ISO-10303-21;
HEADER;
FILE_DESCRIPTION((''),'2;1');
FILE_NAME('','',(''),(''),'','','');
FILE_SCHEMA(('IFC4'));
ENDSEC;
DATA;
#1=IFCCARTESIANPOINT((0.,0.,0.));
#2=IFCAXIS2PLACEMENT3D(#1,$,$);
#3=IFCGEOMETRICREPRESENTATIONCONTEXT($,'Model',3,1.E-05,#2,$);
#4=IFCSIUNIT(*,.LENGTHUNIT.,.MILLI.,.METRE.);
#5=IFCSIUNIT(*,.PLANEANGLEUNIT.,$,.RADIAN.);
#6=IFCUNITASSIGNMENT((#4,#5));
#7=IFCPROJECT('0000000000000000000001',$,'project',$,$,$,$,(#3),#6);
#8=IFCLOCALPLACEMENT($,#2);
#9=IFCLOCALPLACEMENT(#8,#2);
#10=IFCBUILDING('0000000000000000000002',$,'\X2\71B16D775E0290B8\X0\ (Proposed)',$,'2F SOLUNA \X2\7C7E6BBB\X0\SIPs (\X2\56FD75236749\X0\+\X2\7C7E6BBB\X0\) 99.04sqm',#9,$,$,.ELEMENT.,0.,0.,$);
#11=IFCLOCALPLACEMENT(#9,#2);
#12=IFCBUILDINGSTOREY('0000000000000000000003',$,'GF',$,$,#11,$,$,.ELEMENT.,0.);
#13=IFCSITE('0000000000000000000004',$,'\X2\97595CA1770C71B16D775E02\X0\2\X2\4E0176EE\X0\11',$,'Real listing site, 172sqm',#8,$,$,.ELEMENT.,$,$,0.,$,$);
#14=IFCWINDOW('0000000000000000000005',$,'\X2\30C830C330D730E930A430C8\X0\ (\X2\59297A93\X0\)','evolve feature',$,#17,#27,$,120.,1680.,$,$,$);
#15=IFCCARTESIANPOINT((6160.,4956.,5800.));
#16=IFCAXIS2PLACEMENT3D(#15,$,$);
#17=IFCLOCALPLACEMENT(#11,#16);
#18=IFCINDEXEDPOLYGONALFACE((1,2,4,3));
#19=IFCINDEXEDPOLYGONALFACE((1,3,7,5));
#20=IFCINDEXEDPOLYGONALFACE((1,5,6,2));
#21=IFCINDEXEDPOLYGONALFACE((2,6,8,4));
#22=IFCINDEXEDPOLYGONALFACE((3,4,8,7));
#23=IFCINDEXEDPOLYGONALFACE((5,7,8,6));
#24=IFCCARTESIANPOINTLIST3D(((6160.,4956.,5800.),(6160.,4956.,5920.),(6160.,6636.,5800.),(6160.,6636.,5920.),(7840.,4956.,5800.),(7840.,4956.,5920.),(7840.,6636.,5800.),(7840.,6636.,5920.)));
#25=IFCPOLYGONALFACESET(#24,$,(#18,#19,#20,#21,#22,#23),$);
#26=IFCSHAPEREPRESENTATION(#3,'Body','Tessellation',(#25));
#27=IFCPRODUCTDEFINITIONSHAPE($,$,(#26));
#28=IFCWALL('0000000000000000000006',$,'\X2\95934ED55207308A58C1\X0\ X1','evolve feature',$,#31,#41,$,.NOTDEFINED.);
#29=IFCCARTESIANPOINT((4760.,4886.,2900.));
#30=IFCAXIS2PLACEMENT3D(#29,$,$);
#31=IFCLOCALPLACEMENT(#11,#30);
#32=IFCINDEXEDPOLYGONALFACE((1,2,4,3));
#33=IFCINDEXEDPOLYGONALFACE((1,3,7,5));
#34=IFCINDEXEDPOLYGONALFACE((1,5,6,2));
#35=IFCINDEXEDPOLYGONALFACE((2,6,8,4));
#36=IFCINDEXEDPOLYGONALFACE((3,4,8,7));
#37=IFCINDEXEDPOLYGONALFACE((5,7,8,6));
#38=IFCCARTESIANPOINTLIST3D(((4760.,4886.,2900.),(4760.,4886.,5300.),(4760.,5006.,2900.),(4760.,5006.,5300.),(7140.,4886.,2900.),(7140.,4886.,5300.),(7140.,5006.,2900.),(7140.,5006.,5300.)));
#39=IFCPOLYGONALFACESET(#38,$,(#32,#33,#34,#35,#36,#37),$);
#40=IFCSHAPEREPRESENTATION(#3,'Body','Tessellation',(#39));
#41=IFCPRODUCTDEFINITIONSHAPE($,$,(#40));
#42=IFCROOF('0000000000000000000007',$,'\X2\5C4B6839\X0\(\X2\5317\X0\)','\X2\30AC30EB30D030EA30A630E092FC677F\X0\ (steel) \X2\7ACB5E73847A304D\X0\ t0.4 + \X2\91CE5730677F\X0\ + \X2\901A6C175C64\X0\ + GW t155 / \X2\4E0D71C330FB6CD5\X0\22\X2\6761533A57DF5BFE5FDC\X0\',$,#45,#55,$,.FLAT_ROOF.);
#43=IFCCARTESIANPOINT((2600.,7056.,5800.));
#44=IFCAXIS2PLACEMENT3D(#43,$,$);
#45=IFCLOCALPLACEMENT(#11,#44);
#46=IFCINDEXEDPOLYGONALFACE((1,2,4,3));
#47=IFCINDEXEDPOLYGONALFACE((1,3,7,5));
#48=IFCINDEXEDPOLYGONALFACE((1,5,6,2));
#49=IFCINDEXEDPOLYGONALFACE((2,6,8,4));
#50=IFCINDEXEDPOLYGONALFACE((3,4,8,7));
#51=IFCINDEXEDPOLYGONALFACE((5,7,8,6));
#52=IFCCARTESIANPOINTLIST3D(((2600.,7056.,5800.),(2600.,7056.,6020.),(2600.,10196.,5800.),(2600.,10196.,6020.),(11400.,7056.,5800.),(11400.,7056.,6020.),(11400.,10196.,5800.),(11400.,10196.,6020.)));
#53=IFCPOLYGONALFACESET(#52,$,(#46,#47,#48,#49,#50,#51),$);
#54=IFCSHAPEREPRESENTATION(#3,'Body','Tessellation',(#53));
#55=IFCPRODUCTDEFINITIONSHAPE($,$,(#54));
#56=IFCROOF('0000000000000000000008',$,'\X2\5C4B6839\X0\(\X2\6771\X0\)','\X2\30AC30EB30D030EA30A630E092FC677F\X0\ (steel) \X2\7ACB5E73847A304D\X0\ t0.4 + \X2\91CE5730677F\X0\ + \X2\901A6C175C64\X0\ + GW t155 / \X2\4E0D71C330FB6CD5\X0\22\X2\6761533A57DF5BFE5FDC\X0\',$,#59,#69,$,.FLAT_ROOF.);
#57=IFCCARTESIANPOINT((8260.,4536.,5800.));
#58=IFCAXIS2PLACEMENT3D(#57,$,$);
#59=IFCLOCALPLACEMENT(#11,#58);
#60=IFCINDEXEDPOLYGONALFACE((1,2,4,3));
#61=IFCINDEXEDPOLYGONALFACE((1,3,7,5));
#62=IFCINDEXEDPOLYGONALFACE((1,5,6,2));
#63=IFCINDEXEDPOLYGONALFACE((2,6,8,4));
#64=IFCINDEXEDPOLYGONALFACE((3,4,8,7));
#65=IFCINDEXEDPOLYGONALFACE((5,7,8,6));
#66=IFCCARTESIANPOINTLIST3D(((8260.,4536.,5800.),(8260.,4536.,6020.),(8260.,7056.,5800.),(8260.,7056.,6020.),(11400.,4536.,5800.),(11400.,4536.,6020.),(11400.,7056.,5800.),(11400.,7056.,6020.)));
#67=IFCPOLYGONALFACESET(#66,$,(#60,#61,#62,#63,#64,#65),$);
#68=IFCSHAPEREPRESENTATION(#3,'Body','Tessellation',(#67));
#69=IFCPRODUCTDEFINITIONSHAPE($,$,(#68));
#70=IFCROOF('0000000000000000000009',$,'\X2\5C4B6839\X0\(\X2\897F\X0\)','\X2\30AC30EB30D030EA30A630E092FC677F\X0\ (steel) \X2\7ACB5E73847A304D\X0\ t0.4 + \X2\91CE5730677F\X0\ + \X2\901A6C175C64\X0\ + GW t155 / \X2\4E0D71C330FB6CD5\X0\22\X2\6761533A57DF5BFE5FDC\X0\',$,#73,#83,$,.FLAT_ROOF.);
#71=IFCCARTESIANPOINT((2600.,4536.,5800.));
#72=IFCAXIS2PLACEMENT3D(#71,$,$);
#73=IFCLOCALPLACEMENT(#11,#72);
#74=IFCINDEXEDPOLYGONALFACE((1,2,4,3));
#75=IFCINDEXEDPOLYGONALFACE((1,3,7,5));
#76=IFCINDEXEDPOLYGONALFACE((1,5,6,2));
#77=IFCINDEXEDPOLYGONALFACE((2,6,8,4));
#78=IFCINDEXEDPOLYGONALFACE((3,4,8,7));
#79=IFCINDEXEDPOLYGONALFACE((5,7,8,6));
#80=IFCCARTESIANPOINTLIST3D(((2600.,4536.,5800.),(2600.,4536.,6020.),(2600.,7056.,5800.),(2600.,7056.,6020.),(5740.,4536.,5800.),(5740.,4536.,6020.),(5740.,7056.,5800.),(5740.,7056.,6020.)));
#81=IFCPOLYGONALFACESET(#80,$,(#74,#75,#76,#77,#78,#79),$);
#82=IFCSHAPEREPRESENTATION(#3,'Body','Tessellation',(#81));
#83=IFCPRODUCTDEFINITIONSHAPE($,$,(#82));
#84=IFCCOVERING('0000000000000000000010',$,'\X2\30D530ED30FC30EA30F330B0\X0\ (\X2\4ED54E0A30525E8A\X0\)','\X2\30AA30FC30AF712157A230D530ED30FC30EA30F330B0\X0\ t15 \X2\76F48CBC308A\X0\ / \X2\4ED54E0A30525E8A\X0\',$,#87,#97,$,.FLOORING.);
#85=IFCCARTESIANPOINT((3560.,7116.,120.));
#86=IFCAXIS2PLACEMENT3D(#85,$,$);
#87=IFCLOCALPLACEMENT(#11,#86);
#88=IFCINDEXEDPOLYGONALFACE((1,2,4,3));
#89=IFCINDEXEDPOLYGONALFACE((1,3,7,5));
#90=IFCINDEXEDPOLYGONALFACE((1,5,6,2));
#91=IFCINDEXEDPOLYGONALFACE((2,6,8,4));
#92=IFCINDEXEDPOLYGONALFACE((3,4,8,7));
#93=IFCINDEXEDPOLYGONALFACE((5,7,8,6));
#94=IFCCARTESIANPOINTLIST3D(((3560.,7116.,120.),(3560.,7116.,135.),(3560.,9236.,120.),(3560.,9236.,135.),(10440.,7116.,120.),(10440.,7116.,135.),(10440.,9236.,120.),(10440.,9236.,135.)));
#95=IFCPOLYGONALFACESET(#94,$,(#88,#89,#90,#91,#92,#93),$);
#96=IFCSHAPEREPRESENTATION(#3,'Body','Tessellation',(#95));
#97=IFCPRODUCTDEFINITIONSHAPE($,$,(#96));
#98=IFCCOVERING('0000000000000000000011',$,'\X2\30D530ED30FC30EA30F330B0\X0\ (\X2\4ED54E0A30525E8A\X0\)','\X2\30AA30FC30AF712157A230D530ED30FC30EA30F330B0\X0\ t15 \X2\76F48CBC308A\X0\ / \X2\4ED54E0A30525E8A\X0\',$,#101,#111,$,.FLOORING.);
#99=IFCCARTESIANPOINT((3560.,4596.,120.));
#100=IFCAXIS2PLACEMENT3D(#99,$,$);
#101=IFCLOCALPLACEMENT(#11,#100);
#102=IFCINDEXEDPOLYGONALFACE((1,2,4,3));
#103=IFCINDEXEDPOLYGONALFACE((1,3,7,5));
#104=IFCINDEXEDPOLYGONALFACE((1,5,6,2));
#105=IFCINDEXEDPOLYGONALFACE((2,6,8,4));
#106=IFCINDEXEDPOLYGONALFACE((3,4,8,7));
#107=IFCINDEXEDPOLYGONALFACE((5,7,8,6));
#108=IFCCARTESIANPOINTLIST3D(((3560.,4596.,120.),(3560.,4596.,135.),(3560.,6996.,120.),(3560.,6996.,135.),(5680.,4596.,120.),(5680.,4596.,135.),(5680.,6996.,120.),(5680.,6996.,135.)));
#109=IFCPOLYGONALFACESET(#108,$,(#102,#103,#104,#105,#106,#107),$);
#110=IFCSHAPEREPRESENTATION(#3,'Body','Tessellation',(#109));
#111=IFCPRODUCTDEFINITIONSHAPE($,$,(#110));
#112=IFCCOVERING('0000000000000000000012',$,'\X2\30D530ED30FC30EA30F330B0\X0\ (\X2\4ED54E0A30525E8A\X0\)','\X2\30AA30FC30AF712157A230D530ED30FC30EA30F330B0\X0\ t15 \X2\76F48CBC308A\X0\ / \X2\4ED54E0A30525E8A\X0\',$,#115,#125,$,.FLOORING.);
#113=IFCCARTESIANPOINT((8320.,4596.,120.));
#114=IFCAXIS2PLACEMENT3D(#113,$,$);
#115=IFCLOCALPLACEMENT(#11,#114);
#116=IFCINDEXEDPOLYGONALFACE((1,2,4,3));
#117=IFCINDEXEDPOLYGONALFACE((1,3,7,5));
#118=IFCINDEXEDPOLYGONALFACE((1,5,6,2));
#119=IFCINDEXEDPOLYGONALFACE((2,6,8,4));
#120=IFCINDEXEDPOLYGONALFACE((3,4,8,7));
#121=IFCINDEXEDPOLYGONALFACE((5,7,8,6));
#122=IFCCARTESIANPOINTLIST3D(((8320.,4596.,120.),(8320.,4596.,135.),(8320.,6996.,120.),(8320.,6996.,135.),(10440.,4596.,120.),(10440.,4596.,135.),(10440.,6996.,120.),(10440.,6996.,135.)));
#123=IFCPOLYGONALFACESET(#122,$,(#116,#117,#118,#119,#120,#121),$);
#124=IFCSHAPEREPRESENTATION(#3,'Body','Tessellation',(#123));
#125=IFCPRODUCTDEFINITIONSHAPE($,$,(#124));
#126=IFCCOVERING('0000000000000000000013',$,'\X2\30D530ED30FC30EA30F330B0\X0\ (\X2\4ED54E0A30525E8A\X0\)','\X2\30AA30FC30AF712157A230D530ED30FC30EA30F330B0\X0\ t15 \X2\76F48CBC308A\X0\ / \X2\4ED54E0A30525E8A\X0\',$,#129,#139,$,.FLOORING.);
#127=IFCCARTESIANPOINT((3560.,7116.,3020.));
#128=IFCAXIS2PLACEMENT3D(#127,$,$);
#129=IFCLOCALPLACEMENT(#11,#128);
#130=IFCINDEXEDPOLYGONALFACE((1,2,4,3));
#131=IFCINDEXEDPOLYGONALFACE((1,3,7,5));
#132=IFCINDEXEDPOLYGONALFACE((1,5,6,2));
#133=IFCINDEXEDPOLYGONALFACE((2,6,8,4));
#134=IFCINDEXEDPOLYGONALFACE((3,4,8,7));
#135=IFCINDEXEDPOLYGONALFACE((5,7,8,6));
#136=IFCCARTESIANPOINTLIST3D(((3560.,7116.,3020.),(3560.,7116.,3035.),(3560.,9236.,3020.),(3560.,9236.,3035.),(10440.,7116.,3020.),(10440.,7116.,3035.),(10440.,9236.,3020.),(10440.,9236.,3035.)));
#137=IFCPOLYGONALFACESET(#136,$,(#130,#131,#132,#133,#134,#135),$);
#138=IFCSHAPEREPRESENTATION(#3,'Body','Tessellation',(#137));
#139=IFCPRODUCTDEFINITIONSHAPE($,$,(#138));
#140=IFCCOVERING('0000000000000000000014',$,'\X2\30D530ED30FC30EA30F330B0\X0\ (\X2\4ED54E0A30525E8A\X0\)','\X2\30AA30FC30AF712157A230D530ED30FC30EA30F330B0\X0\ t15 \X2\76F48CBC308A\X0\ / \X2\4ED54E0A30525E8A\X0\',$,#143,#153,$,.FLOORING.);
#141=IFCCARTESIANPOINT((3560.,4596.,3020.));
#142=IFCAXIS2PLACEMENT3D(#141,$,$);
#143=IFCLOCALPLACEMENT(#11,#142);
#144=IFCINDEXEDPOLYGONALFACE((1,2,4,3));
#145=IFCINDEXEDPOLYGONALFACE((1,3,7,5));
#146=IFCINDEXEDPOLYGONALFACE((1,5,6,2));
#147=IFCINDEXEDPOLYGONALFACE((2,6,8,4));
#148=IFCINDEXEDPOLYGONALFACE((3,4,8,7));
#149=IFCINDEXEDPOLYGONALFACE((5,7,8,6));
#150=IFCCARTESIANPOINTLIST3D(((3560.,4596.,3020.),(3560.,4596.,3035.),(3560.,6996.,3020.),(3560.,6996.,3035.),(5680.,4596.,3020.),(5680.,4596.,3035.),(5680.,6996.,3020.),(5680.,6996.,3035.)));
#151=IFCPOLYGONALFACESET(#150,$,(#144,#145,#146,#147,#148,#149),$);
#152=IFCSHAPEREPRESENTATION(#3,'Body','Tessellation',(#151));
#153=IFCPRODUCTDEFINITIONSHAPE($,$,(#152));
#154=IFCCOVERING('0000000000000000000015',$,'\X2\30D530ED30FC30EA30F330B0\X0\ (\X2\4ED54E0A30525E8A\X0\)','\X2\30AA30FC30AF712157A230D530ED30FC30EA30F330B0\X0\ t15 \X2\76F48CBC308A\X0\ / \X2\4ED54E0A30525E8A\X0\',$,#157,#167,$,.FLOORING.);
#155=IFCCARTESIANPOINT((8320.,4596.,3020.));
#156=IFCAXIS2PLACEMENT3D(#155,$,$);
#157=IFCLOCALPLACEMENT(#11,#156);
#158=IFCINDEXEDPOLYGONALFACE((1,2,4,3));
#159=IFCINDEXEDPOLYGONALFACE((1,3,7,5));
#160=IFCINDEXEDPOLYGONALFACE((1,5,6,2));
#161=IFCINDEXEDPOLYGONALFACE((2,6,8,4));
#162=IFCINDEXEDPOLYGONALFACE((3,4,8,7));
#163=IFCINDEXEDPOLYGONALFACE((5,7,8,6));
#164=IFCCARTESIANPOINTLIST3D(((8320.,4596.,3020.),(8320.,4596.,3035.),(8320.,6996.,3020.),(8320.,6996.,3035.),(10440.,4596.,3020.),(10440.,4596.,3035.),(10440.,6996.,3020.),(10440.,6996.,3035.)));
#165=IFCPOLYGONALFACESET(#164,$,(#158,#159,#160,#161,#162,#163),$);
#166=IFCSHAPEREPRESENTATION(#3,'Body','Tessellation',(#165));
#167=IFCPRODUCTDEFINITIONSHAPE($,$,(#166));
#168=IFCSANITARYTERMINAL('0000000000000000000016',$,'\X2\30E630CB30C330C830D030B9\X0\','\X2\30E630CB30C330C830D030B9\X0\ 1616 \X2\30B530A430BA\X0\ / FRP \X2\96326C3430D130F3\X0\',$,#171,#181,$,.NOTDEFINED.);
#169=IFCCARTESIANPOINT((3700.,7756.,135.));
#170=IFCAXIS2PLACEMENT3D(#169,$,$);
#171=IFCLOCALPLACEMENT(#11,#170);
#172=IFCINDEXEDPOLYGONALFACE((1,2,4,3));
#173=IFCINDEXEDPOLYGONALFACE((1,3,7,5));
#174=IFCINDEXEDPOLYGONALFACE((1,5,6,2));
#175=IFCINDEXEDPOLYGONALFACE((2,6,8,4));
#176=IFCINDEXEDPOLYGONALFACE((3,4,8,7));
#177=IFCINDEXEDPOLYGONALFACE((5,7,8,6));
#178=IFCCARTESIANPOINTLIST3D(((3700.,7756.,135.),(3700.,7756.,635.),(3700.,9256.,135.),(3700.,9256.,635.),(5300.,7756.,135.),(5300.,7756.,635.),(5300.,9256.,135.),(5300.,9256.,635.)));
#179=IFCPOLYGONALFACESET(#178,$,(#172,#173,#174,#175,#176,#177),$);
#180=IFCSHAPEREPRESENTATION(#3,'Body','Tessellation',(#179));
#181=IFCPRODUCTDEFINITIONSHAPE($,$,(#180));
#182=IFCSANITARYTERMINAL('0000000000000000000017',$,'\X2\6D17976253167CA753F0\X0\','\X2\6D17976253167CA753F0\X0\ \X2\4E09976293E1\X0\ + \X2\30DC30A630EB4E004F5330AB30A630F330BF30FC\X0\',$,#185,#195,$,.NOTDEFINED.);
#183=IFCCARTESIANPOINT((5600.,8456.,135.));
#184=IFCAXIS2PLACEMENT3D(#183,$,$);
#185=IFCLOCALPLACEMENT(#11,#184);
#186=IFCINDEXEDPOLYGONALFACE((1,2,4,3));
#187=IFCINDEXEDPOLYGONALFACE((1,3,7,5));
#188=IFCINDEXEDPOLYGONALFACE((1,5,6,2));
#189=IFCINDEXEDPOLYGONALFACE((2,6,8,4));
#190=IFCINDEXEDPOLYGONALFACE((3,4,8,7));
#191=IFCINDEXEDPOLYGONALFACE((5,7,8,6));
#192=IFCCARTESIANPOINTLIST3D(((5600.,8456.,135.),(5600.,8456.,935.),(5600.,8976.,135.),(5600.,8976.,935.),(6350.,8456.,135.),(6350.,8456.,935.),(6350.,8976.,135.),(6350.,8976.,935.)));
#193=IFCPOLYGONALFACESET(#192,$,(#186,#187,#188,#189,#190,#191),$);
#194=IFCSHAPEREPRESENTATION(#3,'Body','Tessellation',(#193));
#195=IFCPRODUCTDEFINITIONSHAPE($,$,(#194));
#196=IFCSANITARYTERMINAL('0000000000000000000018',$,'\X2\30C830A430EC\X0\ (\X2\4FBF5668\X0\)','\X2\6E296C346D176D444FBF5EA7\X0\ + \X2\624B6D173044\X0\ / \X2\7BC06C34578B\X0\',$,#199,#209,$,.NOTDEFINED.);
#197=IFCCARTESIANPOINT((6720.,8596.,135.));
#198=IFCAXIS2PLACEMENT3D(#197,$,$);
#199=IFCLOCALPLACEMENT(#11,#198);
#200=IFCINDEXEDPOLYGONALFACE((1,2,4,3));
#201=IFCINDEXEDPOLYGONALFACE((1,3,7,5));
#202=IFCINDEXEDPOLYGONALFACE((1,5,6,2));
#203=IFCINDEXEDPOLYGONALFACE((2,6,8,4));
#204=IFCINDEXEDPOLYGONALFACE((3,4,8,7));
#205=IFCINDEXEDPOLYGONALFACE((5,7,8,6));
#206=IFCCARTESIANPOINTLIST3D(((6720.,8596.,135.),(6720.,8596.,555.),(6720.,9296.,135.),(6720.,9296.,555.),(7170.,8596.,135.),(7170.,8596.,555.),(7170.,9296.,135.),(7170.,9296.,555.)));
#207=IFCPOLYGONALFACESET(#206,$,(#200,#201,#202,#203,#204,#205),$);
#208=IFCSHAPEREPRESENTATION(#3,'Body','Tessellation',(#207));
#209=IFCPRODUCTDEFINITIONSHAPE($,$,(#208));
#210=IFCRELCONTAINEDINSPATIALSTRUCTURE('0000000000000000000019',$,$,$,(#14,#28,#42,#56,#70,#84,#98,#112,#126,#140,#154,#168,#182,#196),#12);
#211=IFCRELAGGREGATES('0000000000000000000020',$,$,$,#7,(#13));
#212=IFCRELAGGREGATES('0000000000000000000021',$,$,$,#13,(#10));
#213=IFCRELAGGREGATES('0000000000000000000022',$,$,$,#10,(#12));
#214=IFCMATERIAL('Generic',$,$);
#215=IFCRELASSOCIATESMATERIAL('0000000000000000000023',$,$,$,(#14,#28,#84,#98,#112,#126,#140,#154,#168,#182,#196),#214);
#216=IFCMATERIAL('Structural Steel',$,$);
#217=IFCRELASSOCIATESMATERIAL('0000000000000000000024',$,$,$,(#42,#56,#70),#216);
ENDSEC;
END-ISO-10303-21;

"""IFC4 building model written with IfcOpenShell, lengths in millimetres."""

from ifc_helpers import new_model, si_unit, frame, frame_2d, origin, place, context, project, spatial, rectangle, extrude, material, element, save


model = new_model("IFC4")

# Units and contexts
model_context = context("Model", 3, precision=1e-05, world=origin())
ifc_project = project(units=[si_unit("LENGTHUNIT", "METRE", prefix="MILLI"), si_unit("PLANEANGLEUNIT", "RADIAN")], contexts=[model_context])

# Site, building, storey
site_placement = place(None, origin())
site = spatial("IfcSite", under=ifc_project, at=site_placement, Name="静岡県熱海市2丁目11", ObjectType="Real listing site, 172sqm", CompositionType="ELEMENT", RefElevation=0.0)
building_placement = place(site_placement, origin())
building = spatial("IfcBuilding", under=site, at=building_placement, Name="熱海市邸 (Proposed)", ObjectType="2F SOLUNA 籾殻SIPs (国産杉+籾殻) 99.04sqm", CompositionType="ELEMENT", ElevationOfRefHeight=0.0, ElevationOfTerrain=0.0)
storey_placement = place(building_placement, origin())
storey = spatial("IfcBuildingStorey", under=building, at=storey_placement, Name="GF", CompositionType="ELEMENT", Elevation=0.0)

# Window
ifc_material_1 = material(Name="Generic")
window_1_placement = place(storey_placement, frame((6160.0, 4956.0, 5800.0)))
element("IfcWindow", 1, at=window_1_placement, inside=storey, material=ifc_material_1, Name="トップライト (天窓)", Description="evolve feature", OverallHeight=120.0, OverallWidth=1680.0, context=model_context, shape_type="SweptSolid", body=[
    extrude(rectangle(XDim=1680.0, YDim=1680.0, at=frame_2d((840.0, 840.0))), frame((6160.0, 4956.0, 5800.0)), (0.0, 0.0, 1.0), 120.0),
])

# Wall
wall_1_placement = place(storey_placement, frame((4760.0, 4886.0, 2900.0)))
element("IfcWall", 2, at=wall_1_placement, inside=storey, material=ifc_material_1, Name="間仕切り壁 X1", Description="evolve feature", PredefinedType="NOTDEFINED", context=model_context, shape_type="SweptSolid", body=[
    extrude(rectangle(XDim=2380.0, YDim=120.0, at=frame_2d((1190.0, 60.0))), frame((4760.0, 4886.0, 2900.0)), (0.0, 0.0, 1.0), 2400.0),
])

# Roofs
ifc_material_2 = material(Name="Structural Steel")
roof_1_placement = place(storey_placement, frame((2600.0, 7056.0, 5800.0)))
element("IfcRoof", 3, at=roof_1_placement, inside=storey, material=ifc_material_2, Name="屋根(北)", Description="ガルバリウム鋼板 (steel) 立平葺き t0.4 + 野地板 + 通気層 + GW t155 / 不燃・法22条区域対応", PredefinedType="FLAT_ROOF", context=model_context, shape_type="SweptSolid", body=[
    extrude(rectangle(XDim=8800.0, YDim=3140.0, at=frame_2d((4400.0, 1570.0))), frame((2600.0, 7056.0, 5800.0)), (0.0, 0.0, 1.0), 220.0),
])
roof_2_placement = place(storey_placement, frame((8260.0, 4536.0, 5800.0)))
element("IfcRoof", 4, at=roof_2_placement, inside=storey, material=ifc_material_2, Name="屋根(東)", Description="ガルバリウム鋼板 (steel) 立平葺き t0.4 + 野地板 + 通気層 + GW t155 / 不燃・法22条区域対応", PredefinedType="FLAT_ROOF", context=model_context, shape_type="SweptSolid", body=[
    extrude(rectangle(XDim=3140.0, YDim=2520.0, at=frame_2d((1570.0, 1260.0))), frame((8260.0, 4536.0, 5800.0)), (0.0, 0.0, 1.0), 220.0),
])
roof_3_placement = place(storey_placement, frame((2600.0, 4536.0, 5800.0)))
element("IfcRoof", 5, at=roof_3_placement, inside=storey, material=ifc_material_2, Name="屋根(西)", Description="ガルバリウム鋼板 (steel) 立平葺き t0.4 + 野地板 + 通気層 + GW t155 / 不燃・法22条区域対応", PredefinedType="FLAT_ROOF", context=model_context, shape_type="SweptSolid", body=[
    extrude(rectangle(XDim=3140.0, YDim=2520.0, at=frame_2d((1570.0, 1260.0))), frame((2600.0, 4536.0, 5800.0)), (0.0, 0.0, 1.0), 220.0),
])

# Coverings
covering_1_placement = place(storey_placement, frame((3560.0, 7116.0, 120.0)))
element("IfcCovering", 6, at=covering_1_placement, inside=storey, material=ifc_material_1, Name="フローリング (仕上げ床)", Description="オーク無垢フローリング t15 直貼り / 仕上げ床", PredefinedType="FLOORING", context=model_context, shape_type="SweptSolid", body=[
    extrude(rectangle(XDim=6880.0, YDim=2120.0, at=frame_2d((3440.0, 1060.0))), frame((3560.0, 7116.0, 120.0)), (0.0, 0.0, 1.0), 15.0),
])
covering_2_placement = place(storey_placement, frame((3560.0, 4596.0, 120.0)))
element("IfcCovering", 7, at=covering_2_placement, inside=storey, material=ifc_material_1, Name="フローリング (仕上げ床)", Description="オーク無垢フローリング t15 直貼り / 仕上げ床", PredefinedType="FLOORING", context=model_context, shape_type="SweptSolid", body=[
    extrude(rectangle(XDim=2120.0, YDim=2400.0, at=frame_2d((1060.0, 1200.0))), frame((3560.0, 4596.0, 120.0)), (0.0, 0.0, 1.0), 15.0),
])
covering_3_placement = place(storey_placement, frame((8320.0, 4596.0, 120.0)))
element("IfcCovering", 8, at=covering_3_placement, inside=storey, material=ifc_material_1, Name="フローリング (仕上げ床)", Description="オーク無垢フローリング t15 直貼り / 仕上げ床", PredefinedType="FLOORING", context=model_context, shape_type="SweptSolid", body=[
    extrude(rectangle(XDim=2120.0, YDim=2400.0, at=frame_2d((1060.0, 1200.0))), frame((8320.0, 4596.0, 120.0)), (0.0, 0.0, 1.0), 15.0),
])
covering_4_placement = place(storey_placement, frame((3560.0, 7116.0, 3020.0)))
element("IfcCovering", 9, at=covering_4_placement, inside=storey, material=ifc_material_1, Name="フローリング (仕上げ床)", Description="オーク無垢フローリング t15 直貼り / 仕上げ床", PredefinedType="FLOORING", context=model_context, shape_type="SweptSolid", body=[
    extrude(rectangle(XDim=6880.0, YDim=2120.0, at=frame_2d((3440.0, 1060.0))), frame((3560.0, 7116.0, 3020.0)), (0.0, 0.0, 1.0), 15.0),
])
covering_5_placement = place(storey_placement, frame((3560.0, 4596.0, 3020.0)))
element("IfcCovering", 10, at=covering_5_placement, inside=storey, material=ifc_material_1, Name="フローリング (仕上げ床)", Description="オーク無垢フローリング t15 直貼り / 仕上げ床", PredefinedType="FLOORING", context=model_context, shape_type="SweptSolid", body=[
    extrude(rectangle(XDim=2120.0, YDim=2400.0, at=frame_2d((1060.0, 1200.0))), frame((3560.0, 4596.0, 3020.0)), (0.0, 0.0, 1.0), 15.0),
])
covering_6_placement = place(storey_placement, frame((8320.0, 4596.0, 3020.0)))
element("IfcCovering", 11, at=covering_6_placement, inside=storey, material=ifc_material_1, Name="フローリング (仕上げ床)", Description="オーク無垢フローリング t15 直貼り / 仕上げ床", PredefinedType="FLOORING", context=model_context, shape_type="SweptSolid", body=[
    extrude(rectangle(XDim=2120.0, YDim=2400.0, at=frame_2d((1060.0, 1200.0))), frame((8320.0, 4596.0, 3020.0)), (0.0, 0.0, 1.0), 15.0),
])

# Sanitary terminals
sanitary_terminal_1_placement = place(storey_placement, frame((3700.0, 7756.0, 135.0)))
element("IfcSanitaryTerminal", 12, at=sanitary_terminal_1_placement, inside=storey, material=ifc_material_1, Name="ユニットバス", Description="ユニットバス 1616 サイズ / FRP 防水パン", PredefinedType="NOTDEFINED", context=model_context, shape_type="SweptSolid", body=[
    extrude(rectangle(XDim=1600.0, YDim=1500.0, at=frame_2d((800.0, 750.0))), frame((3700.0, 7756.0, 135.0)), (0.0, 0.0, 1.0), 500.0),
])
sanitary_terminal_2_placement = place(storey_placement, frame((5600.0, 8456.0, 135.0)))
element("IfcSanitaryTerminal", 13, at=sanitary_terminal_2_placement, inside=storey, material=ifc_material_1, Name="洗面化粧台", Description="洗面化粧台 三面鏡 + ボウル一体カウンター", PredefinedType="NOTDEFINED", context=model_context, shape_type="SweptSolid", body=[
    extrude(rectangle(XDim=750.0, YDim=520.0, at=frame_2d((375.0, 260.0))), frame((5600.0, 8456.0, 135.0)), (0.0, 0.0, 1.0), 800.0),
])
sanitary_terminal_3_placement = place(storey_placement, frame((6720.0, 8596.0, 135.0)))
element("IfcSanitaryTerminal", 14, at=sanitary_terminal_3_placement, inside=storey, material=ifc_material_1, Name="トイレ (便器)", Description="温水洗浄便座 + 手洗い / 節水型", PredefinedType="NOTDEFINED", context=model_context, shape_type="SweptSolid", body=[
    extrude(rectangle(XDim=450.0, YDim=700.0, at=frame_2d((225.0, 350.0))), frame((6720.0, 8596.0, 135.0)), (0.0, 0.0, 1.0), 420.0),
])

save(model, "model.ifc")
